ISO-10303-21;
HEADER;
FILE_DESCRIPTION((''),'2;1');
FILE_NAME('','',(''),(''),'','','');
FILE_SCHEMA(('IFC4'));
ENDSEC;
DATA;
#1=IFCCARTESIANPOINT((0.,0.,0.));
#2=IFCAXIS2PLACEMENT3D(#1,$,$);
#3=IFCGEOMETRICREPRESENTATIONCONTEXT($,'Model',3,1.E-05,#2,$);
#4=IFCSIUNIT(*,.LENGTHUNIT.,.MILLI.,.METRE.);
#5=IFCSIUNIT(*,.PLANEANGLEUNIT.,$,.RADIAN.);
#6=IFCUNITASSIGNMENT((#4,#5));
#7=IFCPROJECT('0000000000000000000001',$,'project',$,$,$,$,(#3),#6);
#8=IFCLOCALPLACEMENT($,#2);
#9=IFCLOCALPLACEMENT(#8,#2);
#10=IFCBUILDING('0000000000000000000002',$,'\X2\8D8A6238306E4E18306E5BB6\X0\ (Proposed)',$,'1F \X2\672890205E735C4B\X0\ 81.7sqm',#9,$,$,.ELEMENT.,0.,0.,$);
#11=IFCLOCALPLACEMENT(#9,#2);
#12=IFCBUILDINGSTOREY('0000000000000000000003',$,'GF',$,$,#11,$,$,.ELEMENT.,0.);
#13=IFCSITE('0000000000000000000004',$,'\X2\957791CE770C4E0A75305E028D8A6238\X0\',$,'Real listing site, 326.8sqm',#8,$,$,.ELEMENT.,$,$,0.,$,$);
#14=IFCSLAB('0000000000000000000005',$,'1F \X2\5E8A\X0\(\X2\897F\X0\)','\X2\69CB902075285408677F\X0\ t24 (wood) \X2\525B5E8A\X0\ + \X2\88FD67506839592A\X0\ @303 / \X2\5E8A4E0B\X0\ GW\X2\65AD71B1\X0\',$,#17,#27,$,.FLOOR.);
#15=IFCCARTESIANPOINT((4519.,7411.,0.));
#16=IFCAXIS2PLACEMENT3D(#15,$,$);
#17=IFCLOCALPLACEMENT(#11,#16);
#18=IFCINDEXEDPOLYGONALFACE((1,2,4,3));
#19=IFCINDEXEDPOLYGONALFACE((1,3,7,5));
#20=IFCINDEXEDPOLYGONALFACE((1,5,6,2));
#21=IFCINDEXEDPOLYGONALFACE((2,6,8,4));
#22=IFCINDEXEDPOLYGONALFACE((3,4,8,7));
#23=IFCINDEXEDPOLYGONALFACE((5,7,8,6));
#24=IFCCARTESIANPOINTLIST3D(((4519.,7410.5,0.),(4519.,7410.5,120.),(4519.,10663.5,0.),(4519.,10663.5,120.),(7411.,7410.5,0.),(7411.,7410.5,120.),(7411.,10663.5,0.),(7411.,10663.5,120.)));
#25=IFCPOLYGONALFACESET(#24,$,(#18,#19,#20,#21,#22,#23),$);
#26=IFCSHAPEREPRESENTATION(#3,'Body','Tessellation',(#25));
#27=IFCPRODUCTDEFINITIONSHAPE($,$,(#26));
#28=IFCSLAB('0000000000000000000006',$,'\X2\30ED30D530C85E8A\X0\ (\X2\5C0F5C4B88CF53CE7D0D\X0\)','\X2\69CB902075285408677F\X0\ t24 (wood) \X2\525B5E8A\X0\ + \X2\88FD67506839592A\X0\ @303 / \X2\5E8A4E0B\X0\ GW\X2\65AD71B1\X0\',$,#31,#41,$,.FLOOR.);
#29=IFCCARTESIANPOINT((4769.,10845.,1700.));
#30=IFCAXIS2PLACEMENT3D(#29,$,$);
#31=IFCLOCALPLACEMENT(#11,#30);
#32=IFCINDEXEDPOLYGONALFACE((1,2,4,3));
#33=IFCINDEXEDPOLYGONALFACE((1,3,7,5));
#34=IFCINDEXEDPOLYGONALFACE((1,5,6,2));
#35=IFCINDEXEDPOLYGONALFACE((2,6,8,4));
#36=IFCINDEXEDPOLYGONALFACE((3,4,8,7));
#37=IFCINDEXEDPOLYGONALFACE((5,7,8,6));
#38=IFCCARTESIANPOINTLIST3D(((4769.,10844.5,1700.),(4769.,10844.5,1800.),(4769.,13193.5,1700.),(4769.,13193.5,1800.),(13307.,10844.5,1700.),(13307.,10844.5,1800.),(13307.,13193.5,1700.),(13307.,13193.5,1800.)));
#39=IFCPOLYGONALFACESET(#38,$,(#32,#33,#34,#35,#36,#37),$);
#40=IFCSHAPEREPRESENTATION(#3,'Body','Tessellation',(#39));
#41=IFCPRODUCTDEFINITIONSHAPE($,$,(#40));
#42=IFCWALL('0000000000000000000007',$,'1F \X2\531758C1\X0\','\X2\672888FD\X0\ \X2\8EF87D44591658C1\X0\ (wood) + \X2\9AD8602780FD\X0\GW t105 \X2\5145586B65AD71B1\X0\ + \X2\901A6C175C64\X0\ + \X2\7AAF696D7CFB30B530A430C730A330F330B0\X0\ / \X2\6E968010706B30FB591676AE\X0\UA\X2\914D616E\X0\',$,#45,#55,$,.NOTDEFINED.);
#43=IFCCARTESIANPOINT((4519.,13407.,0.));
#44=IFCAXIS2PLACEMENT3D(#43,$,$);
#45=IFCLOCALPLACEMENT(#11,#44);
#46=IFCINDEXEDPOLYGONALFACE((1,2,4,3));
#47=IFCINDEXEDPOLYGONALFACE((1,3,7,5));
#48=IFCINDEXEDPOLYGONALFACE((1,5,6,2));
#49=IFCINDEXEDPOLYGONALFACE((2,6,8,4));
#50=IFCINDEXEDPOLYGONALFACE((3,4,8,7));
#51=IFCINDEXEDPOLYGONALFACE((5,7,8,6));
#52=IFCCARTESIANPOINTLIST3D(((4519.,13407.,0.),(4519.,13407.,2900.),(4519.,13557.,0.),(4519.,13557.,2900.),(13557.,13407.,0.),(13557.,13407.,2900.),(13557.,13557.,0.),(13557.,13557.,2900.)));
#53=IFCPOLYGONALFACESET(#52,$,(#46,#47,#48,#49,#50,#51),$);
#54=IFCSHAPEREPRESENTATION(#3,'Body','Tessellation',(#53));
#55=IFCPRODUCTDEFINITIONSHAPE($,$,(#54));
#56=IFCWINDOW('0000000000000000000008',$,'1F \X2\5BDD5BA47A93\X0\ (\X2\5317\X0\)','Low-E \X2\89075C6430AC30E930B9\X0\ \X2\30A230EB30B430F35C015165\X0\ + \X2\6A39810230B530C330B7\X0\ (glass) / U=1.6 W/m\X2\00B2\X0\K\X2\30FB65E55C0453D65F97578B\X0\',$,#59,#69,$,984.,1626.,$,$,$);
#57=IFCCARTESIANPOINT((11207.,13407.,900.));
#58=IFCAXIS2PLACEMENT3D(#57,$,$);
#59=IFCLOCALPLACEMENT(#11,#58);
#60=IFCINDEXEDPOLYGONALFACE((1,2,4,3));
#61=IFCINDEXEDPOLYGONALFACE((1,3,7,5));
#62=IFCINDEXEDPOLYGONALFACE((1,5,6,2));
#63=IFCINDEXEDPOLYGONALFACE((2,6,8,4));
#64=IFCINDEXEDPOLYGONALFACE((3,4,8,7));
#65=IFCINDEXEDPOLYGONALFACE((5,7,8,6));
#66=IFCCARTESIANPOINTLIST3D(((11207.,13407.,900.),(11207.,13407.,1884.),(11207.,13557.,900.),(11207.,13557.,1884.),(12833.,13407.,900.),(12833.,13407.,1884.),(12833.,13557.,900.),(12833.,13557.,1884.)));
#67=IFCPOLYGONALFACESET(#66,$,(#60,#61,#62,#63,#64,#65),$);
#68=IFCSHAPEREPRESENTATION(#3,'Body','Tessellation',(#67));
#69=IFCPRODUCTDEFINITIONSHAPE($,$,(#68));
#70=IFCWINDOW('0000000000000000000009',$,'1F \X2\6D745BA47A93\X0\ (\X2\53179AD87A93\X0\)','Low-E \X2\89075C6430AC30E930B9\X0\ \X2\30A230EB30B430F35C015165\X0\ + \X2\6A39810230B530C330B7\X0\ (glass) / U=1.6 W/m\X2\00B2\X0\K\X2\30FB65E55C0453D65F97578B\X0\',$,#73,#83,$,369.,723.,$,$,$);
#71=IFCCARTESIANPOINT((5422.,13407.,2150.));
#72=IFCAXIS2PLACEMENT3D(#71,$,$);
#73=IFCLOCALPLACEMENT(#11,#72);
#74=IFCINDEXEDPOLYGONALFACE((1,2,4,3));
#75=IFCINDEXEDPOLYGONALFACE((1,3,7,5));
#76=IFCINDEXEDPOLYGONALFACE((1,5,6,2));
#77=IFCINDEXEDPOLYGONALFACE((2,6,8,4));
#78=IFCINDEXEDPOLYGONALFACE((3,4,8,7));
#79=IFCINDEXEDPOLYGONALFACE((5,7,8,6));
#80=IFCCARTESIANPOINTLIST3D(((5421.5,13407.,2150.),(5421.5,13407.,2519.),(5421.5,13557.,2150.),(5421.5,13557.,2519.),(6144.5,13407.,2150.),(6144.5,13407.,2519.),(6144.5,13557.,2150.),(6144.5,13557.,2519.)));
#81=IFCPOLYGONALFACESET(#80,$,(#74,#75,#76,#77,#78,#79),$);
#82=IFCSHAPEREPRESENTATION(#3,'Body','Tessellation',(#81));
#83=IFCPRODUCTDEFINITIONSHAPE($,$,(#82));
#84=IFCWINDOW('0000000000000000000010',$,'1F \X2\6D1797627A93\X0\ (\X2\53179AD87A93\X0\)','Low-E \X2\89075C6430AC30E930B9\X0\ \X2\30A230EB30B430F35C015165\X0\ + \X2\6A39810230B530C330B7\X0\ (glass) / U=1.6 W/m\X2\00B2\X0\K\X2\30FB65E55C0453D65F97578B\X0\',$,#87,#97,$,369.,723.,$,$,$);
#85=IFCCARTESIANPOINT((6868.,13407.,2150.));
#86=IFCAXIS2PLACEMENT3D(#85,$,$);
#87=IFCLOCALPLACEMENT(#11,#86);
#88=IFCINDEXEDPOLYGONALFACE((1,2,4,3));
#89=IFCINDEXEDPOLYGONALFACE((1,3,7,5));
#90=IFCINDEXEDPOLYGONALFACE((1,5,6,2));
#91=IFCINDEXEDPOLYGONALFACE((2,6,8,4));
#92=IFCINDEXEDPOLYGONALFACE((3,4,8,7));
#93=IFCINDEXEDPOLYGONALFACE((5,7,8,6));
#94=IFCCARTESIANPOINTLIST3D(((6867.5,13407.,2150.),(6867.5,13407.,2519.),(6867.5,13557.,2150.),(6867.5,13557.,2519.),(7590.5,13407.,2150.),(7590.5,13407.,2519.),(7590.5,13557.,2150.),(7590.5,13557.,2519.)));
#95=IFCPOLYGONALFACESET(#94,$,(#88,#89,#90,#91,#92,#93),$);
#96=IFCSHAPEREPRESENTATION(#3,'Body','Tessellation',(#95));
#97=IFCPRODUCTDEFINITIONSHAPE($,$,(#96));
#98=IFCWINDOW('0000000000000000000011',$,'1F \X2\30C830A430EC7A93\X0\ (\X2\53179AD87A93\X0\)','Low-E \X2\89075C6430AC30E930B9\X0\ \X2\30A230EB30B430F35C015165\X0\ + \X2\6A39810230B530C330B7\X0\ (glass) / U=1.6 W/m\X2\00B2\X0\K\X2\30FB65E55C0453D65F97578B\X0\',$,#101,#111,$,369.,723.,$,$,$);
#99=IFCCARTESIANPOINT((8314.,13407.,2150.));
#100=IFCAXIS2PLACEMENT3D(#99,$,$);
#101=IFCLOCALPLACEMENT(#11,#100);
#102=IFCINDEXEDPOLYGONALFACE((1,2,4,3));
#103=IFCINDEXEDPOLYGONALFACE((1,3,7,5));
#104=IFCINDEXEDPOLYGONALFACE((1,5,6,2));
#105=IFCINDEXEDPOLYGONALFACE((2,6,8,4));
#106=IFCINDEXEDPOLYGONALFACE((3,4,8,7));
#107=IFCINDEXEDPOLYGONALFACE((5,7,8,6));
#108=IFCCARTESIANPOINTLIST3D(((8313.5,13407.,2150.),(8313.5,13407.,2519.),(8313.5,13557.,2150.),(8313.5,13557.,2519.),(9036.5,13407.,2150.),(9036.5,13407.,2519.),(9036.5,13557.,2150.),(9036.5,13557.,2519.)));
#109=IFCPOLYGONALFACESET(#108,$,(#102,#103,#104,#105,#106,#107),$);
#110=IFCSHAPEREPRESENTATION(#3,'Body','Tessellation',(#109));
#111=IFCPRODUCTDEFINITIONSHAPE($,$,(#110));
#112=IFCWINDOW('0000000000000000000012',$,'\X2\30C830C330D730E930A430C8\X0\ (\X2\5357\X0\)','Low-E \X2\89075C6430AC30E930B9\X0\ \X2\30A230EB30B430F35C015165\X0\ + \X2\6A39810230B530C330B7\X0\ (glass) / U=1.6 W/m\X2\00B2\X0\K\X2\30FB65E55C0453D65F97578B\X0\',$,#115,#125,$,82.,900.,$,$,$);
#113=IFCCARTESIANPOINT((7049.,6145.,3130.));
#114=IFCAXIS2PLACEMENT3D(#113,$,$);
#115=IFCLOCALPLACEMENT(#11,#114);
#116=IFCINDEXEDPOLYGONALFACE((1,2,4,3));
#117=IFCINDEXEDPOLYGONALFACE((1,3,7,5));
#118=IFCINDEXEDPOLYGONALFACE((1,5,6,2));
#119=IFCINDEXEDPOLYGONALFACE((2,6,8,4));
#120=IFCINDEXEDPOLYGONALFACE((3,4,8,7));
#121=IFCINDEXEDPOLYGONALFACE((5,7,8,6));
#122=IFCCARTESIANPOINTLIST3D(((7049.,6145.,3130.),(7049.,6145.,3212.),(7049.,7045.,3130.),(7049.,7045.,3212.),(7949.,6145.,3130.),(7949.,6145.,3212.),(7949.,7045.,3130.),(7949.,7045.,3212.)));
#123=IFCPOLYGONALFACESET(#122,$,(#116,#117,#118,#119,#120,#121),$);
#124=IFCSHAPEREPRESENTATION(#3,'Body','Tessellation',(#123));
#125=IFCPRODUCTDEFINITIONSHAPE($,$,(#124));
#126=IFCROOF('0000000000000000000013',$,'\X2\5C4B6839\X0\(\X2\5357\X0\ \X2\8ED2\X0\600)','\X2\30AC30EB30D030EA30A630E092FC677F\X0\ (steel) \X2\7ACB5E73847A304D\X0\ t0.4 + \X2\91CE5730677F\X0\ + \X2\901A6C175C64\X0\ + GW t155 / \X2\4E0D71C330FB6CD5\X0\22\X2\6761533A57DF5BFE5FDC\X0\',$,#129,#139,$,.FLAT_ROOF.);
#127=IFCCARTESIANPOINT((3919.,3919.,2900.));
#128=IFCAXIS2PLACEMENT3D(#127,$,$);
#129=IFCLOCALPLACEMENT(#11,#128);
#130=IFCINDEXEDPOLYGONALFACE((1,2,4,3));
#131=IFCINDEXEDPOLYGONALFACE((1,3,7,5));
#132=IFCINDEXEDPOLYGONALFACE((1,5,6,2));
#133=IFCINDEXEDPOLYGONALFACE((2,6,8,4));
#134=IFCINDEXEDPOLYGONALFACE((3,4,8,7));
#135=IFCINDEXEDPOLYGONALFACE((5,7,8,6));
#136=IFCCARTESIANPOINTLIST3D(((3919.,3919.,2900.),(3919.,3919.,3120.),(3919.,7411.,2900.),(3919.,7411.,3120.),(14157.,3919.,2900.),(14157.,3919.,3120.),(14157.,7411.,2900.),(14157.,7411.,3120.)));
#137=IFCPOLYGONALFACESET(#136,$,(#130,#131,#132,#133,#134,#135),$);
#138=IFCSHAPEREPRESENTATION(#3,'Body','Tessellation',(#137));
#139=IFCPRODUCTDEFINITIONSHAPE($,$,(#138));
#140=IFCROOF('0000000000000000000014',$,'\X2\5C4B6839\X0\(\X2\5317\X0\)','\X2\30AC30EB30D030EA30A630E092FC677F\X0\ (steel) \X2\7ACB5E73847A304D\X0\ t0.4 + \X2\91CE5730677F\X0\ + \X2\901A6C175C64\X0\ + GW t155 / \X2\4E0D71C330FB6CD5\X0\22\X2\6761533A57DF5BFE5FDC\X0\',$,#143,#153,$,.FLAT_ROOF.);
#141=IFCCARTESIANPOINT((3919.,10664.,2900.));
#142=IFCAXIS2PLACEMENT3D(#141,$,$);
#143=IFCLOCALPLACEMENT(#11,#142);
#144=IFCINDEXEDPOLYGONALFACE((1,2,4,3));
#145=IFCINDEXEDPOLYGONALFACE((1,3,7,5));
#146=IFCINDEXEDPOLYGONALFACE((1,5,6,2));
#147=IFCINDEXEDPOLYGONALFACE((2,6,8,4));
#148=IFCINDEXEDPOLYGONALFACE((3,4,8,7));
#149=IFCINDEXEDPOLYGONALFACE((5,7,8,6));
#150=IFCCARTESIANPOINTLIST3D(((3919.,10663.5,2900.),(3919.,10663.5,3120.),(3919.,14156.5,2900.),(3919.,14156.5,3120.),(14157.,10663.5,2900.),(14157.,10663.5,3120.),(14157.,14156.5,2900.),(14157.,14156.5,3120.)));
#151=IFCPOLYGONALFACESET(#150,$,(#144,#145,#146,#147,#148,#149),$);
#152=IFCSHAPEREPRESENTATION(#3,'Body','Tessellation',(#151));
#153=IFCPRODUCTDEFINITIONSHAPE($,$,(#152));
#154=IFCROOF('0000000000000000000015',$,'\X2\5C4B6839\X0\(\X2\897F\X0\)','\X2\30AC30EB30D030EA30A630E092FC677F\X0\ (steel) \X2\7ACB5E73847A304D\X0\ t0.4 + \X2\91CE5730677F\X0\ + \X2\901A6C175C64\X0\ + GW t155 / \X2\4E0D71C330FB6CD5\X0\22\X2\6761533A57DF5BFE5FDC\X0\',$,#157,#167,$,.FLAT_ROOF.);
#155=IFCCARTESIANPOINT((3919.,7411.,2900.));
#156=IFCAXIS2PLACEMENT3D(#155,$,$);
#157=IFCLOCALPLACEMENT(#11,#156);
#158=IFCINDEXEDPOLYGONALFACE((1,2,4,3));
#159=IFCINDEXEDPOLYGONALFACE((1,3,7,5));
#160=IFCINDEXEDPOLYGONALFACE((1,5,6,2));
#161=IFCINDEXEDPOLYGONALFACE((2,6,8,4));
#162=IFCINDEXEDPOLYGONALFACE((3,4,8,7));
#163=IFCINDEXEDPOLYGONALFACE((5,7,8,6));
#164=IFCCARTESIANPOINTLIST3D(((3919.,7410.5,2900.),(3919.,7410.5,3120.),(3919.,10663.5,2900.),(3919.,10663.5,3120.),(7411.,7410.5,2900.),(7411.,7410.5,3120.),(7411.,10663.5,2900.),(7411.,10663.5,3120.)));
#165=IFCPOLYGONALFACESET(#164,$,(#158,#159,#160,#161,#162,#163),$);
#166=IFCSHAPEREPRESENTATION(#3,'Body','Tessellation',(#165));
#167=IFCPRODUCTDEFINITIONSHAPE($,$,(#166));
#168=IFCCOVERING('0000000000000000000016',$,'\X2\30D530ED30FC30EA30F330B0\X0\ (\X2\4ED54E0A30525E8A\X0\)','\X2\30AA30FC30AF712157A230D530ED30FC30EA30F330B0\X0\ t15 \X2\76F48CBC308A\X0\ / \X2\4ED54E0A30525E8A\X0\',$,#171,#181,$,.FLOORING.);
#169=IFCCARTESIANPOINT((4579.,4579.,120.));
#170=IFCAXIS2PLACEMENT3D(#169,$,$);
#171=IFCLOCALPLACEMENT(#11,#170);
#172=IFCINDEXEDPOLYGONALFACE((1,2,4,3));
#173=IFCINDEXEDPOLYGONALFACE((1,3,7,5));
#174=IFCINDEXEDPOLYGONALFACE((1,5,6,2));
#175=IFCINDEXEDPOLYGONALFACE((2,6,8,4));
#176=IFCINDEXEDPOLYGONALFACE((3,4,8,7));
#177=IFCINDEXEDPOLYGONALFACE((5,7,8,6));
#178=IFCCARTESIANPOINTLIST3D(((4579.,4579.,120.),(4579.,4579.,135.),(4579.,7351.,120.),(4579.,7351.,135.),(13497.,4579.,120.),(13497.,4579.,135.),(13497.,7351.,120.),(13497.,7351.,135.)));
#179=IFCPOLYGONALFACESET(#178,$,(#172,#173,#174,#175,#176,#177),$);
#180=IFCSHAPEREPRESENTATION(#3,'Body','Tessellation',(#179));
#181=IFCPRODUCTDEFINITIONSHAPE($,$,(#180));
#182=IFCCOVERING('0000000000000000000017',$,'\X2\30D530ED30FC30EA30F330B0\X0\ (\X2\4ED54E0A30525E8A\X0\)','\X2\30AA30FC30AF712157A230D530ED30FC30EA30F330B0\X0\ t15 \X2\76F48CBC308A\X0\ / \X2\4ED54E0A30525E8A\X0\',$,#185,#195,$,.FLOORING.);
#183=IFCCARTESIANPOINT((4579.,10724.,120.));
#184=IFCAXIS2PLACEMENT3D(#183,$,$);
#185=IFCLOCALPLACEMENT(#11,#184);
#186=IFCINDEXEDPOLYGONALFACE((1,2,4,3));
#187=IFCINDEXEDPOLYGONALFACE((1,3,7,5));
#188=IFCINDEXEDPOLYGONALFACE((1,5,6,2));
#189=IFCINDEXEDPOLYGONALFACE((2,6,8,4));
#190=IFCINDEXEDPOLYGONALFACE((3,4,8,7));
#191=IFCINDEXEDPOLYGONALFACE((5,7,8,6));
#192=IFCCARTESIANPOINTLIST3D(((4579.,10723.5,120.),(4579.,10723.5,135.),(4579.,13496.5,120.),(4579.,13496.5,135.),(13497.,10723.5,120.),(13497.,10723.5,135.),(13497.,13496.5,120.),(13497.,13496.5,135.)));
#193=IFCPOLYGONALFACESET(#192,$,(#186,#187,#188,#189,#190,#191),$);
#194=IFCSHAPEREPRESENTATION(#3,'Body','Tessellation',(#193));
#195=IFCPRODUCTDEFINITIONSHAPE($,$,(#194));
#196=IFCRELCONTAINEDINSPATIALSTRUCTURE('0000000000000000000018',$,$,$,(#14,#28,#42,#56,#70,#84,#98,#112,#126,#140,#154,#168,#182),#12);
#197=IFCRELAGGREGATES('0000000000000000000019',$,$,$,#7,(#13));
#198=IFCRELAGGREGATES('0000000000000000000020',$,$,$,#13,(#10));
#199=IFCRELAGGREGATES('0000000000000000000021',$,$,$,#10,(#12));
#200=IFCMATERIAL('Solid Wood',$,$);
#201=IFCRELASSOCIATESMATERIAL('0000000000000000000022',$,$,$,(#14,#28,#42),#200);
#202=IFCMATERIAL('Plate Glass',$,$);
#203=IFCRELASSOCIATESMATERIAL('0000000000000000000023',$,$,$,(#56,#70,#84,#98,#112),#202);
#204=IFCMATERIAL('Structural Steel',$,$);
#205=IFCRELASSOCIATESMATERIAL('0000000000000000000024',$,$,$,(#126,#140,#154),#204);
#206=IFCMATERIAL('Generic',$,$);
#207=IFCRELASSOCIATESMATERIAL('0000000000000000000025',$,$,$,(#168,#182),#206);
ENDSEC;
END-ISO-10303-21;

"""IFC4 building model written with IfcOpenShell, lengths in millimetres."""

from ifc_helpers import new_model, si_unit, frame, frame_2d, origin, place, context, project, spatial, rectangle, extrude, material, element, fill, save


model = new_model("IFC4")

# Units and contexts
model_context = context("Model", 3, precision=1e-05, world=origin())
ifc_project = project(units=[si_unit("LENGTHUNIT", "METRE", prefix="MILLI"), si_unit("PLANEANGLEUNIT", "RADIAN")], contexts=[model_context])

# Site, building, storey
site_placement = place(None, origin())
site = spatial("IfcSite", under=ifc_project, at=site_placement, Name="長野県上田市越戸", ObjectType="Real listing site, 326.8sqm", CompositionType="ELEMENT", RefElevation=0.0)
building_placement = place(site_placement, origin())
building = spatial("IfcBuilding", under=site, at=building_placement, Name="越戸の丘の家 (Proposed)", ObjectType="1F 木造平屋 81.7sqm", CompositionType="ELEMENT", ElevationOfRefHeight=0.0, ElevationOfTerrain=0.0)
storey_placement = place(building_placement, origin())
storey = spatial("IfcBuildingStorey", under=building, at=storey_placement, Name="GF", CompositionType="ELEMENT", Elevation=0.0)

# Slabs
ifc_material_1 = material(Name="Solid Wood")
slab_1_placement = place(storey_placement, frame((4519.0, 7411.0, 0.0)))
element("IfcSlab", 1, at=slab_1_placement, inside=storey, material=ifc_material_1, Name="1F 床(西)", Description="構造用合板 t24 (wood) 剛床 + 製材根太 @303 / 床下 GW断熱", PredefinedType="FLOOR", context=model_context, shape_type="SweptSolid", body=[
    extrude(rectangle(XDim=2892.0, YDim=3253.0, at=frame_2d((1446.0, 1626.0))), frame((4519.0, 7411.0, 0.0)), (0.0, 0.0, 1.0), 120.0),
])
slab_2_placement = place(storey_placement, frame((4769.0, 10845.0, 1700.0)))
element("IfcSlab", 2, at=slab_2_placement, inside=storey, material=ifc_material_1, Name="ロフト床 (小屋裏収納)", Description="構造用合板 t24 (wood) 剛床 + 製材根太 @303 / 床下 GW断熱", PredefinedType="FLOOR", context=model_context, shape_type="SweptSolid", body=[
    extrude(rectangle(XDim=8538.0, YDim=2349.0, at=frame_2d((4269.0, 1174.0))), frame((4769.0, 10845.0, 1700.0)), (0.0, 0.0, 1.0), 100.0),
])

# Shared definitions
ifc_material_2 = material(Name="Plate Glass")

# Wall, openings, windows
wall_1_placement = place(storey_placement, frame((4519.0, 13407.0, 0.0)))
wall_1 = element("IfcWall", 3, at=wall_1_placement, inside=storey, material=ifc_material_1, Name="1F 北壁", Description="木製 軸組外壁 (wood) + 高性能GW t105 充填断熱 + 通気層 + 窯業系サイディング / 準耐火・外皮UA配慮", PredefinedType="NOTDEFINED", context=model_context, shape_type="SweptSolid", body=[
    extrude(rectangle(XDim=9038.0, YDim=150.0, at=frame_2d((4519.0, 75.0))), frame((4519.0, 13407.0, 0.0)), (0.0, 0.0, 1.0), 2900.0),
])
opening_1_placement = place(storey_placement, frame((11207.0, 13407.0, 900.0)))
opening_1 = element("IfcOpeningElement", 4, at=opening_1_placement, cuts=wall_1, PredefinedType="NOTDEFINED", context=model_context, shape_type="SweptSolid", body=[
    extrude(rectangle(XDim=1626.0, YDim=150.0, at=frame_2d((813.0, 75.0))), frame((11207.0, 13407.0, 900.0)), (0.0, 0.0, 1.0), 984.0),
])
opening_2_placement = place(storey_placement, frame((5422.0, 13407.0, 2150.0)))
opening_2 = element("IfcOpeningElement", 5, at=opening_2_placement, cuts=wall_1, PredefinedType="NOTDEFINED", context=model_context, shape_type="SweptSolid", body=[
    extrude(rectangle(XDim=723.0, YDim=150.0, at=frame_2d((361.0, 75.0))), frame((5422.0, 13407.0, 2150.0)), (0.0, 0.0, 1.0), 369.0),
])
opening_3_placement = place(storey_placement, frame((6868.0, 13407.0, 2150.0)))
opening_3 = element("IfcOpeningElement", 6, at=opening_3_placement, cuts=wall_1, PredefinedType="NOTDEFINED", context=model_context, shape_type="SweptSolid", body=[
    extrude(rectangle(XDim=723.0, YDim=150.0, at=frame_2d((361.0, 75.0))), frame((6868.0, 13407.0, 2150.0)), (0.0, 0.0, 1.0), 369.0),
])
opening_4_placement = place(storey_placement, frame((8314.0, 13407.0, 2150.0)))
opening_4 = element("IfcOpeningElement", 7, at=opening_4_placement, cuts=wall_1, PredefinedType="NOTDEFINED", context=model_context, shape_type="SweptSolid", body=[
    extrude(rectangle(XDim=723.0, YDim=150.0, at=frame_2d((361.0, 75.0))), frame((8314.0, 13407.0, 2150.0)), (0.0, 0.0, 1.0), 369.0),
])
window_1_placement = place(storey_placement, frame((11207.0, 13407.0, 900.0)))
window_1 = element("IfcWindow", 8, at=window_1_placement, inside=storey, material=ifc_material_2, Name="1F 寝室窓 (北)", Description="Low-E 複層ガラス アルゴン封入 + 樹脂サッシ (glass) / U=1.6 W/m²K・日射取得型", OverallHeight=984.0, OverallWidth=1626.0, context=model_context, shape_type="SweptSolid", body=[
    extrude(rectangle(XDim=1626.0, YDim=150.0, at=frame_2d((813.0, 75.0))), frame((11207.0, 13407.0, 900.0)), (0.0, 0.0, 1.0), 984.0),
])
fill(opening_1, window_1)
window_2_placement = place(storey_placement, frame((5422.0, 13407.0, 2150.0)))
window_2 = element("IfcWindow", 9, at=window_2_placement, inside=storey, material=ifc_material_2, Name="1F 浴室窓 (北高窓)", Description="Low-E 複層ガラス アルゴン封入 + 樹脂サッシ (glass) / U=1.6 W/m²K・日射取得型", OverallHeight=369.0, OverallWidth=723.0, context=model_context, shape_type="SweptSolid", body=[
    extrude(rectangle(XDim=723.0, YDim=150.0, at=frame_2d((361.0, 75.0))), frame((5422.0, 13407.0, 2150.0)), (0.0, 0.0, 1.0), 369.0),
])
fill(opening_2, window_2)
window_3_placement = place(storey_placement, frame((6868.0, 13407.0, 2150.0)))
window_3 = element("IfcWindow", 10, at=window_3_placement, inside=storey, material=ifc_material_2, Name="1F 洗面窓 (北高窓)", Description="Low-E 複層ガラス アルゴン封入 + 樹脂サッシ (glass) / U=1.6 W/m²K・日射取得型", OverallHeight=369.0, OverallWidth=723.0, context=model_context, shape_type="SweptSolid", body=[
    extrude(rectangle(XDim=723.0, YDim=150.0, at=frame_2d((361.0, 75.0))), frame((6868.0, 13407.0, 2150.0)), (0.0, 0.0, 1.0), 369.0),
])
fill(opening_3, window_3)
window_4_placement = place(storey_placement, frame((8314.0, 13407.0, 2150.0)))
window_4 = element("IfcWindow", 11, at=window_4_placement, inside=storey, material=ifc_material_2, Name="1F トイレ窓 (北高窓)", Description="Low-E 複層ガラス アルゴン封入 + 樹脂サッシ (glass) / U=1.6 W/m²K・日射取得型", OverallHeight=369.0, OverallWidth=723.0, context=model_context, shape_type="SweptSolid", body=[
    extrude(rectangle(XDim=723.0, YDim=150.0, at=frame_2d((361.0, 75.0))), frame((8314.0, 13407.0, 2150.0)), (0.0, 0.0, 1.0), 369.0),
])
fill(opening_4, window_4)

# Window
window_5_placement = place(storey_placement, frame((7049.0, 6145.0, 3130.0)))
element("IfcWindow", 12, at=window_5_placement, inside=storey, material=ifc_material_2, Name="トップライト (南)", Description="Low-E 複層ガラス アルゴン封入 + 樹脂サッシ (glass) / U=1.6 W/m²K・日射取得型", OverallHeight=82.0, OverallWidth=900.0, context=model_context, shape_type="SweptSolid", body=[
    extrude(rectangle(XDim=900.0, YDim=900.0, at=frame_2d((450.0, 450.0))), frame((7049.0, 6145.0, 3130.0)), (0.0, 0.0, 1.0), 82.0),
])

# Roofs
ifc_material_3 = material(Name="Structural Steel")
roof_1_placement = place(storey_placement, frame((3919.0, 3919.0, 2900.0)))
element("IfcRoof", 13, at=roof_1_placement, inside=storey, material=ifc_material_3, Name="屋根(南 軒600)", Description="ガルバリウム鋼板 (steel) 立平葺き t0.4 + 野地板 + 通気層 + GW t155 / 不燃・法22条区域対応", PredefinedType="FLAT_ROOF", context=model_context, shape_type="SweptSolid", body=[
    extrude(rectangle(XDim=10238.0, YDim=3492.0, at=frame_2d((5119.0, 1746.0))), frame((3919.0, 3919.0, 2900.0)), (0.0, 0.0, 1.0), 220.0),
])
roof_2_placement = place(storey_placement, frame((3919.0, 10664.0, 2900.0)))
element("IfcRoof", 14, at=roof_2_placement, inside=storey, material=ifc_material_3, Name="屋根(北)", Description="ガルバリウム鋼板 (steel) 立平葺き t0.4 + 野地板 + 通気層 + GW t155 / 不燃・法22条区域対応", PredefinedType="FLAT_ROOF", context=model_context, shape_type="SweptSolid", body=[
    extrude(rectangle(XDim=10238.0, YDim=3493.0, at=frame_2d((5119.0, 1746.0))), frame((3919.0, 10664.0, 2900.0)), (0.0, 0.0, 1.0), 220.0),
])
roof_3_placement = place(storey_placement, frame((3919.0, 7411.0, 2900.0)))
element("IfcRoof", 15, at=roof_3_placement, inside=storey, material=ifc_material_3, Name="屋根(西)", Description="ガルバリウム鋼板 (steel) 立平葺き t0.4 + 野地板 + 通気層 + GW t155 / 不燃・法22条区域対応", PredefinedType="FLAT_ROOF", context=model_context, shape_type="SweptSolid", body=[
    extrude(rectangle(XDim=3492.0, YDim=3253.0, at=frame_2d((1746.0, 1626.0))), frame((3919.0, 7411.0, 2900.0)), (0.0, 0.0, 1.0), 220.0),
])

# Coverings
ifc_material_4 = material(Name="Generic")
covering_1_placement = place(storey_placement, frame((4579.0, 4579.0, 120.0)))
element("IfcCovering", 16, at=covering_1_placement, inside=storey, material=ifc_material_4, Name="フローリング (仕上げ床)", Description="オーク無垢フローリング t15 直貼り / 仕上げ床", PredefinedType="FLOORING", context=model_context, shape_type="SweptSolid", body=[
    extrude(rectangle(XDim=8918.0, YDim=2772.0, at=frame_2d((4459.0, 1386.0))), frame((4579.0, 4579.0, 120.0)), (0.0, 0.0, 1.0), 15.0),
])
covering_2_placement = place(storey_placement, frame((4579.0, 10724.0, 120.0)))
element("IfcCovering", 17, at=covering_2_placement, inside=storey, material=ifc_material_4, Name="フローリング (仕上げ床)", Description="オーク無垢フローリング t15 直貼り / 仕上げ床", PredefinedType="FLOORING", context=model_context, shape_type="SweptSolid", body=[
    extrude(rectangle(XDim=8918.0, YDim=2773.0, at=frame_2d((4459.0, 1386.0))), frame((4579.0, 10724.0, 120.0)), (0.0, 0.0, 1.0), 15.0),
])

save(model, "model.ifc")
